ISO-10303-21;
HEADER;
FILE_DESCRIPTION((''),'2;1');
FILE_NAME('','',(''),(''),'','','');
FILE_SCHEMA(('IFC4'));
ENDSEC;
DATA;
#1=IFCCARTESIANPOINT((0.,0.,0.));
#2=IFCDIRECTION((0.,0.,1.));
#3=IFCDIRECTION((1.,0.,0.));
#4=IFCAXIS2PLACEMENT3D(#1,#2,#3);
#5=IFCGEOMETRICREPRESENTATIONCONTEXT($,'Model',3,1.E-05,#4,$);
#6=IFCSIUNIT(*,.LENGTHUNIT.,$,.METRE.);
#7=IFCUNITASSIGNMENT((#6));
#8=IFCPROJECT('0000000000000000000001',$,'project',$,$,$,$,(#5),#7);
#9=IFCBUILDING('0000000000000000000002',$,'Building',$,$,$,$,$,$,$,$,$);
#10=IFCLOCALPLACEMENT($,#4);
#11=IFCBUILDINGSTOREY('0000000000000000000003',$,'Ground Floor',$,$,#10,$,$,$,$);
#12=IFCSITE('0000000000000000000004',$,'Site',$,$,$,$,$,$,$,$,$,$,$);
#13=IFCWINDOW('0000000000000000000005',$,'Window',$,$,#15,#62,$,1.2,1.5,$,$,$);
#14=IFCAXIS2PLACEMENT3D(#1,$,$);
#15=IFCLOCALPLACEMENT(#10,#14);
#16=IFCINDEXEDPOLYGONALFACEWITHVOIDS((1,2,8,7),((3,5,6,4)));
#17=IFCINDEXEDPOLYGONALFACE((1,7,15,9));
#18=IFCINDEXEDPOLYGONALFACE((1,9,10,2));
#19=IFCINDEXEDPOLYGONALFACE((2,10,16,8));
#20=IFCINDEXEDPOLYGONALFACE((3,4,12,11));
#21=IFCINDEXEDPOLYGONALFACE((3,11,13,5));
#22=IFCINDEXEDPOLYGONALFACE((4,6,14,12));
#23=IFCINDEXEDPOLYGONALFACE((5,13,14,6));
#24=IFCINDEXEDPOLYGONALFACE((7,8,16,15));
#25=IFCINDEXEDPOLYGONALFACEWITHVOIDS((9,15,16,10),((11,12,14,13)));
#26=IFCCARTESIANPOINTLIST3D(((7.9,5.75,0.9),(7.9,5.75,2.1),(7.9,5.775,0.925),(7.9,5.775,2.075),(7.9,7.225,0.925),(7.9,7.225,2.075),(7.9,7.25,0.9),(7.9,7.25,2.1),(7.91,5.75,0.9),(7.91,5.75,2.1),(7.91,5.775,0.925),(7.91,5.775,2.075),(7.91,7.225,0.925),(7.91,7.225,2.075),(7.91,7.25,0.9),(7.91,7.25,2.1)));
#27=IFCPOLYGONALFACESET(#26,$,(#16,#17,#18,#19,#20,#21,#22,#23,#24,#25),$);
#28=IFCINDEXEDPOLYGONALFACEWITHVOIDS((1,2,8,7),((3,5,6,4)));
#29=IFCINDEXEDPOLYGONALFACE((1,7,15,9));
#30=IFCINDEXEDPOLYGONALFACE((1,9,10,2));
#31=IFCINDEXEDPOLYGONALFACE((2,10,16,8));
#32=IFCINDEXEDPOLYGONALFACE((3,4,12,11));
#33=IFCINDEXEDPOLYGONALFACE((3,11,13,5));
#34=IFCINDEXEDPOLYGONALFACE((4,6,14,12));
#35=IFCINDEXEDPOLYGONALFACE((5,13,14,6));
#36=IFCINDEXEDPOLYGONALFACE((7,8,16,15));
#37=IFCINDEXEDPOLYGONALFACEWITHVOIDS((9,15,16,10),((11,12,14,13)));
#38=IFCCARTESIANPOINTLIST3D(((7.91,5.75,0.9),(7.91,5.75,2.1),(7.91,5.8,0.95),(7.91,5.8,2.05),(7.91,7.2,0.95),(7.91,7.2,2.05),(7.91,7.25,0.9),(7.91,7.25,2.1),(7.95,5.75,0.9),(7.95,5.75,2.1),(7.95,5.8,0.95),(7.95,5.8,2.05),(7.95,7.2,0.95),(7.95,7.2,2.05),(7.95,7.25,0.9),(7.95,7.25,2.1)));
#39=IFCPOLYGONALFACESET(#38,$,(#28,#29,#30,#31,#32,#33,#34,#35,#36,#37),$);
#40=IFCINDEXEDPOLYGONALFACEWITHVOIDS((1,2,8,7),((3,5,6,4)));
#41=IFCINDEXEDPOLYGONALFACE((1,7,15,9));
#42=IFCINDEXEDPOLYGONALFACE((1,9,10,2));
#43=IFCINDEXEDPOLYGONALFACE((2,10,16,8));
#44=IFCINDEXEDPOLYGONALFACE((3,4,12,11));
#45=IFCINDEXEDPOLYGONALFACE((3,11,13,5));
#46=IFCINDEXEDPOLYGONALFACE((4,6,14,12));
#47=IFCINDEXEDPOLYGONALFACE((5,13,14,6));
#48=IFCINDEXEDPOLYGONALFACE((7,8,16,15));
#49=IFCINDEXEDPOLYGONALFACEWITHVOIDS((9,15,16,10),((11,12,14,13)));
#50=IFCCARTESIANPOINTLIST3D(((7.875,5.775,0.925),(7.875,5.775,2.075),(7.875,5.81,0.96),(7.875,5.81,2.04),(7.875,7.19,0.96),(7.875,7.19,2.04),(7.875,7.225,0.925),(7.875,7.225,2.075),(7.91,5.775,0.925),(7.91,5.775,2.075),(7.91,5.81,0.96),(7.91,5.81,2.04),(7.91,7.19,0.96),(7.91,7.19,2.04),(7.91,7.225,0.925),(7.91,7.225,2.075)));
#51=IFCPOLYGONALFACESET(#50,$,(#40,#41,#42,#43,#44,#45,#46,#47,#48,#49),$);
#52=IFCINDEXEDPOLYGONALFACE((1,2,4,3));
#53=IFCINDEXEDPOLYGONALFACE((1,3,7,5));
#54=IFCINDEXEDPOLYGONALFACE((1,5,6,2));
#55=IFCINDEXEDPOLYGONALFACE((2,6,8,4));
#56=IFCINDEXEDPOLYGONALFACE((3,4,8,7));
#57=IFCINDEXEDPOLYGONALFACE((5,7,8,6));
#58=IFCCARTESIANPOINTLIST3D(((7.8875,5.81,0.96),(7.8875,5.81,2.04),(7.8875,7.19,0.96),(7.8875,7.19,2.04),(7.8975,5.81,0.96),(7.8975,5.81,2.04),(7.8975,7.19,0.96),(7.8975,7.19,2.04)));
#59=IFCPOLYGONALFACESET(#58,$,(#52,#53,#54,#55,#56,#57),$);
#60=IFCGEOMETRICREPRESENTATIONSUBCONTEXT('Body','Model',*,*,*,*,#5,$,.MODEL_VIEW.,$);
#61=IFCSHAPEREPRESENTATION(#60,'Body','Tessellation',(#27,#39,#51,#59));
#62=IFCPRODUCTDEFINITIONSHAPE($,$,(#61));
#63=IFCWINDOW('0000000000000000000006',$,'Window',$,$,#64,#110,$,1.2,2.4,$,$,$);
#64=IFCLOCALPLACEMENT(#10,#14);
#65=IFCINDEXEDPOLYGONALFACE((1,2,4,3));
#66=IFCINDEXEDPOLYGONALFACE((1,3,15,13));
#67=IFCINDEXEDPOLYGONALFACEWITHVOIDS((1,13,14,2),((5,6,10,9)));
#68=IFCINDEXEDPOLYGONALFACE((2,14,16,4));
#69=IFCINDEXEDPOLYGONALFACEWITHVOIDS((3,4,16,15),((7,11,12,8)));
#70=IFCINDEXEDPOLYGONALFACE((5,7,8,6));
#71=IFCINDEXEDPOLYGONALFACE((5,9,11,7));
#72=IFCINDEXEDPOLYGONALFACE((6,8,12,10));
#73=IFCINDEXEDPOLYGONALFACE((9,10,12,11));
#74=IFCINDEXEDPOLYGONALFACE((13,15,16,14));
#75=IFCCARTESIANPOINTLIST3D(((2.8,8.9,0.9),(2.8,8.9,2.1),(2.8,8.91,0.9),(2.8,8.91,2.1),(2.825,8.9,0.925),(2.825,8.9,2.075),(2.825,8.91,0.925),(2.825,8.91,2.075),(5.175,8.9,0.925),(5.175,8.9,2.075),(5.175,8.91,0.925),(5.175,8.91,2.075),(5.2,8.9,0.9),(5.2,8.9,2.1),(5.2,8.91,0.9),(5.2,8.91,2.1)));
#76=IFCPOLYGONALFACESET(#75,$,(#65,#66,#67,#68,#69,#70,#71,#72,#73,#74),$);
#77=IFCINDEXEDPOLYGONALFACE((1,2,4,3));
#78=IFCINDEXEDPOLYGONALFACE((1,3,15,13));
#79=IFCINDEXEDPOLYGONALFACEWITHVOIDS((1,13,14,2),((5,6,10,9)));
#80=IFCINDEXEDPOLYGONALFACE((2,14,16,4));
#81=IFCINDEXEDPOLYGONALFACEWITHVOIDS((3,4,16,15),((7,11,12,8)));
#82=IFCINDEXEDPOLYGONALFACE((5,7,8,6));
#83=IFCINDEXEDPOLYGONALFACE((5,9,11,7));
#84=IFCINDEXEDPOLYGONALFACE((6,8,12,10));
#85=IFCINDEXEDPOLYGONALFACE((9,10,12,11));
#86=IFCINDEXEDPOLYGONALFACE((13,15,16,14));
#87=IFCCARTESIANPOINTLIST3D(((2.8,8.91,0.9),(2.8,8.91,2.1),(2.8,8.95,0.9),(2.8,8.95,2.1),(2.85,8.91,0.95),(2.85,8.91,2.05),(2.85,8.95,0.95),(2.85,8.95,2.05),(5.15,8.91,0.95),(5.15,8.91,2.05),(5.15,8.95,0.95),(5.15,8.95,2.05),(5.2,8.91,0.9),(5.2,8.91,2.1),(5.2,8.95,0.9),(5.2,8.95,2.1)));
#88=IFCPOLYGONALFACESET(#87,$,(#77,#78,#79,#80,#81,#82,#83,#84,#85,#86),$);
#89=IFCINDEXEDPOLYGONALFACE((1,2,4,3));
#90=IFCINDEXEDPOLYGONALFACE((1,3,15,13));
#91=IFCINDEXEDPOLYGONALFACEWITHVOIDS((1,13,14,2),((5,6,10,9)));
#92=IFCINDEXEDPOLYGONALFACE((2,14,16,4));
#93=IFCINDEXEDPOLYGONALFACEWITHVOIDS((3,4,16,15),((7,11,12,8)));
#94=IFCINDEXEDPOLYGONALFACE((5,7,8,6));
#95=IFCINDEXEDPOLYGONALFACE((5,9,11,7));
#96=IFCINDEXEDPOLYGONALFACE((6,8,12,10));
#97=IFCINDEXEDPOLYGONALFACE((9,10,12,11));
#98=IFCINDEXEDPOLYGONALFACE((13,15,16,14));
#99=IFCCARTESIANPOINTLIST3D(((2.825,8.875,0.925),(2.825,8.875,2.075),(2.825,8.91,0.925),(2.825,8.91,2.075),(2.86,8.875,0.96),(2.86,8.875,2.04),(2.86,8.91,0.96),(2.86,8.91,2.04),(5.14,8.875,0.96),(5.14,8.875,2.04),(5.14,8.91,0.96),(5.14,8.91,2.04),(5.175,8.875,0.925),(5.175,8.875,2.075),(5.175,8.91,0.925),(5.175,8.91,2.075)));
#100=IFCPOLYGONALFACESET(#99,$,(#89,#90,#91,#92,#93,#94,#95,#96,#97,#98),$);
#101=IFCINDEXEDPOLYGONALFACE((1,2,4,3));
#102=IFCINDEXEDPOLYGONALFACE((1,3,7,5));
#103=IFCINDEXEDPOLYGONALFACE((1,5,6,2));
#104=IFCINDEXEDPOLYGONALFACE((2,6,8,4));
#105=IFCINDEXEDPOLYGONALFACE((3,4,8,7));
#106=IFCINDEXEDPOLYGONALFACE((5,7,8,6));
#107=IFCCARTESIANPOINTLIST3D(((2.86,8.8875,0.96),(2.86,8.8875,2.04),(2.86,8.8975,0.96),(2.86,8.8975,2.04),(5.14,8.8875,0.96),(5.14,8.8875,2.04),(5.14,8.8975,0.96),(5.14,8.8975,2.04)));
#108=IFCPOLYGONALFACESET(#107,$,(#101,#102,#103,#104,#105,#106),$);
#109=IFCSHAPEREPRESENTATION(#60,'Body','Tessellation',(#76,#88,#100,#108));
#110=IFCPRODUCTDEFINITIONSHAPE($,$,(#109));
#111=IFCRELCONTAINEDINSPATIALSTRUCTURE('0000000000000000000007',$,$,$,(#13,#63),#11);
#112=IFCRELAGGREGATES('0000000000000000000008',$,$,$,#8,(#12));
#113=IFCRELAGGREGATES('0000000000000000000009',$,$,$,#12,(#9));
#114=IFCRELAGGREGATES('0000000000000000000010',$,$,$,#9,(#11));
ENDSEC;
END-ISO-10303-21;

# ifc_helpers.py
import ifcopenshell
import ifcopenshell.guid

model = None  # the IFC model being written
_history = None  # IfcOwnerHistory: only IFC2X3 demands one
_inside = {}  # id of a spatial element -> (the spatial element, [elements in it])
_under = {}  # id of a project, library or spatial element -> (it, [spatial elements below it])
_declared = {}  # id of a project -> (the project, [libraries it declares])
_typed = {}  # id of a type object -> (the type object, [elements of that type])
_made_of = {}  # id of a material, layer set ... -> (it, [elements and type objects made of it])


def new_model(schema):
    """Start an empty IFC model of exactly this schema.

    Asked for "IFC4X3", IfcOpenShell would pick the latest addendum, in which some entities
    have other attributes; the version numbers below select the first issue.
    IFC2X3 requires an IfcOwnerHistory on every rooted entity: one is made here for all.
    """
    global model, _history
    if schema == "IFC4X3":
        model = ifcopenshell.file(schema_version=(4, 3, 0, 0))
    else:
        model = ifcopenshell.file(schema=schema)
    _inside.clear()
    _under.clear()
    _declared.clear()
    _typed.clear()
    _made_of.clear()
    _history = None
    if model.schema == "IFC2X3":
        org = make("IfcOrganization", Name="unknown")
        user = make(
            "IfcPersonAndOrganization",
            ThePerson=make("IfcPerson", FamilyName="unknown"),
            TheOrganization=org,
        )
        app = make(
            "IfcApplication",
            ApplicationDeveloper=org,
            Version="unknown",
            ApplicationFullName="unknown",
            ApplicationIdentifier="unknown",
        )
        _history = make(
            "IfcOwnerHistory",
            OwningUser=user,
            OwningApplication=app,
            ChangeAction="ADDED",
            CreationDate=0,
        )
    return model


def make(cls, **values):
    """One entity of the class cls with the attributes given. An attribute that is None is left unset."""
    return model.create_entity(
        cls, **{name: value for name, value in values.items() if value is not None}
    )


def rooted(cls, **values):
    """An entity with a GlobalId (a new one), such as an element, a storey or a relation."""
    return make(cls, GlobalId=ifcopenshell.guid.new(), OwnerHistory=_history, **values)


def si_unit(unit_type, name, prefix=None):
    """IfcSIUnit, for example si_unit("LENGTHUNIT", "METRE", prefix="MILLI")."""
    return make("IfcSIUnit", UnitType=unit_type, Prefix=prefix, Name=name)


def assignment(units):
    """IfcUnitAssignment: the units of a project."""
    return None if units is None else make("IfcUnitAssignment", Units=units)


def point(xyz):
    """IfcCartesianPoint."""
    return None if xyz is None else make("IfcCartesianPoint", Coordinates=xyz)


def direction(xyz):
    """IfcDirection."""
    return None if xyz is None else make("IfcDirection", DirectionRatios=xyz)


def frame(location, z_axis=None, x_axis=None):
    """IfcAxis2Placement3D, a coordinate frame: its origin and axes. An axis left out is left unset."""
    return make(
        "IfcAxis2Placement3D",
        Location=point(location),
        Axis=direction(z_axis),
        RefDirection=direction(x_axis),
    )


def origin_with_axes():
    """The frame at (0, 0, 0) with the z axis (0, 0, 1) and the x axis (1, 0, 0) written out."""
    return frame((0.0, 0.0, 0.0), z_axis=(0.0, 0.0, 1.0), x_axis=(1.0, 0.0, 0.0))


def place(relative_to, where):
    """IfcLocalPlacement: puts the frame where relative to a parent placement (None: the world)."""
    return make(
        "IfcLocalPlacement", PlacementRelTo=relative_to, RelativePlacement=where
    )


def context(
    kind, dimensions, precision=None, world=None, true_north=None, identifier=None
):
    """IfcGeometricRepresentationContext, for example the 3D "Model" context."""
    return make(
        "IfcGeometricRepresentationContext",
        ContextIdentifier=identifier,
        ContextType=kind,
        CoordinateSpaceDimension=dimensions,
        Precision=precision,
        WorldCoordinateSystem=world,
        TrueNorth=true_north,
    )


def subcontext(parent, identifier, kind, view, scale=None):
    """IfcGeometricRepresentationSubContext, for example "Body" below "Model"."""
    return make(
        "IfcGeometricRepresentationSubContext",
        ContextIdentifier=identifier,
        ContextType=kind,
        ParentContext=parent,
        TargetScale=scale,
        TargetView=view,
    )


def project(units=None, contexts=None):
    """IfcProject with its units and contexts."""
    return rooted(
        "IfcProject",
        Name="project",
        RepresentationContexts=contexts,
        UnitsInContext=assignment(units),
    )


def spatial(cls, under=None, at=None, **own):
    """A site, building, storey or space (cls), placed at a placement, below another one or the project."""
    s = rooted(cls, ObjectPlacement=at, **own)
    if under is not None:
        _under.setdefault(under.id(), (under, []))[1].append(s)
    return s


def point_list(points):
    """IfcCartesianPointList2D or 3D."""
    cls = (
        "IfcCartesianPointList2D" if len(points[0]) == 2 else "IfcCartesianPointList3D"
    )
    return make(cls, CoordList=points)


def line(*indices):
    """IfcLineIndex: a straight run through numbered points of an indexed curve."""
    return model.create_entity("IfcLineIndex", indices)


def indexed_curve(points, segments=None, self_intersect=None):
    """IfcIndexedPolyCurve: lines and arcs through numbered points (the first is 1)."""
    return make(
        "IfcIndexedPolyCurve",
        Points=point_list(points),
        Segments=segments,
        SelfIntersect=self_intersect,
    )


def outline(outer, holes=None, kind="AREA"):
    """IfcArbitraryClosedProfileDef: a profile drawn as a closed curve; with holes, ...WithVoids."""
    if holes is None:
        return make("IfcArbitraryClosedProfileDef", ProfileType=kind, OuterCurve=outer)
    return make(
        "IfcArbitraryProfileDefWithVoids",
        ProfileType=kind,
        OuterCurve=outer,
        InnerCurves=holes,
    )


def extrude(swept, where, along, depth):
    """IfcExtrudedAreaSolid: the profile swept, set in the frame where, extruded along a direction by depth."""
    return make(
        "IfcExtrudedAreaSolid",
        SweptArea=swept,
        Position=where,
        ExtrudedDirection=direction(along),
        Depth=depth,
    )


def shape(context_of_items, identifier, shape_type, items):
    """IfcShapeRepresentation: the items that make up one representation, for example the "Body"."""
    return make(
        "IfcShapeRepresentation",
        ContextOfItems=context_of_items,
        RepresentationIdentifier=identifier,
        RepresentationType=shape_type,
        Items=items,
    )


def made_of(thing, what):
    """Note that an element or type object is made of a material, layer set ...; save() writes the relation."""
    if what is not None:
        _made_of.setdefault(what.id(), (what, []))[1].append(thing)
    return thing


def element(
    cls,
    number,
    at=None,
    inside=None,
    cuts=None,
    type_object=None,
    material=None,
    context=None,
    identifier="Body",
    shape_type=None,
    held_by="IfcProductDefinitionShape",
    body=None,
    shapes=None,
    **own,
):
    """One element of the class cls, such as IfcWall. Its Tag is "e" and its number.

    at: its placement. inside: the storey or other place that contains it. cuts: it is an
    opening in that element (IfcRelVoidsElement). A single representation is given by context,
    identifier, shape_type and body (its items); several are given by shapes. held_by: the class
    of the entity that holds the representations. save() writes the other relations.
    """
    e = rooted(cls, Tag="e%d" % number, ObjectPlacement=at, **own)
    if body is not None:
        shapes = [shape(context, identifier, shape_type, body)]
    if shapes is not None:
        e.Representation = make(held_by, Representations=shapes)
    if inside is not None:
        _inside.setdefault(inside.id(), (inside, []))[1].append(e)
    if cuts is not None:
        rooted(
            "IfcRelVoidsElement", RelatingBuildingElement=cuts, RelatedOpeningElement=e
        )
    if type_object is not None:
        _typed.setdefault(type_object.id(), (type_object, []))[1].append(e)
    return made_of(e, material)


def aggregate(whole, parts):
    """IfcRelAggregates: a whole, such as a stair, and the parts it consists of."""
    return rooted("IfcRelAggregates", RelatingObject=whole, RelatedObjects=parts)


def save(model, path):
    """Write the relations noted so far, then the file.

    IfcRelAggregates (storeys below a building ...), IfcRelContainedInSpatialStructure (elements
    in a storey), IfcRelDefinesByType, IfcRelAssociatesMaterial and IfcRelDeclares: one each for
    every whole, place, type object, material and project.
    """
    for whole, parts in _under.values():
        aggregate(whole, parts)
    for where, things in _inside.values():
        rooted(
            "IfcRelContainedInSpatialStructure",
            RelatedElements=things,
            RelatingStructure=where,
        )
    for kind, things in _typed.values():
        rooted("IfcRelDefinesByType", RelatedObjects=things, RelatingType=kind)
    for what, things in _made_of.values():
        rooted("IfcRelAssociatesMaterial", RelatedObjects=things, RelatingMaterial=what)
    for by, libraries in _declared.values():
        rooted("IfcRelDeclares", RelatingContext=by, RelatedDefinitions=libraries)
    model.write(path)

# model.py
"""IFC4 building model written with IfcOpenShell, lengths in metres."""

from ifc_helpers import new_model, si_unit, frame, origin_with_axes, place, context, subcontext, project, spatial, line, indexed_curve, outline, extrude, element, save


model = new_model("IFC4")

# Units and contexts
model_context = context("Model", 3, precision=1e-05, world=origin_with_axes())
body_context = subcontext(model_context, "Body", "Model", "MODEL_VIEW")
ifc_project = project(units=[si_unit("LENGTHUNIT", "METRE")], contexts=[model_context])

# Site, building, storey
site = spatial("IfcSite", under=ifc_project, Name="Site")
building = spatial("IfcBuilding", under=site, Name="Building")
storey_placement = place(None, origin_with_axes())
storey = spatial("IfcBuildingStorey", under=building, at=storey_placement, Name="Ground Floor")

# Windows
for number, where, z_axis, x_axis, name in (
    (1, (8.0, 5.75, 0.9), (0.0, 0.0, 1.0), (0.0, 1.0, 0.0), "Window"),
):
    element("IfcWindow", number, at=place(storey_placement, frame(where, z_axis=z_axis, x_axis=x_axis)), inside=storey, Name=name, OverallHeight=1.2, OverallWidth=1.5, context=body_context, shape_type="SweptSolid", body=[
        extrude(outline(indexed_curve([(0.0, 0.0), (1.5, 0.0), (1.5, 1.2), (0.0, 1.2)], segments=[line(1, 2, 3, 4, 1)]), holes=[indexed_curve([(0.025, 0.025), (1.475, 0.025), (1.475, 1.175), (0.025, 1.175)], segments=[line(1, 2, 3, 4, 1)])]), frame((0.0, 0.09, 0.0), z_axis=(0.0, -1.0, 0.0), x_axis=(1.0, 0.0, 0.0)), (0.0, 0.0, -1.0), 0.01),
        extrude(outline(indexed_curve([(0.0, 0.0), (1.5, 0.0), (1.5, 1.2), (0.0, 1.2)], segments=[line(1, 2, 3, 4, 1)]), holes=[indexed_curve([(0.05, 0.05), (1.45, 0.05), (1.45, 1.15), (0.05, 1.15)], segments=[line(1, 2, 3, 4, 1)])]), frame((0.0, 0.05, 0.0), z_axis=(0.0, -1.0, 0.0), x_axis=(1.0, 0.0, 0.0)), (0.0, 0.0, -1.0), 0.04),
        extrude(outline(indexed_curve([(0.0, 0.0), (1.45, 0.0), (1.45, 1.15), (0.0, 1.15)], segments=[line(1, 2, 3, 4, 1)]), holes=[indexed_curve([(0.035, 0.035), (1.415, 0.035), (1.415, 1.115), (0.035, 1.115)], segments=[line(1, 2, 3, 4, 1)])]), frame((0.025, 0.09, 0.025), z_axis=(0.0, -1.0, 0.0), x_axis=(1.0, 0.0, 0.0)), (0.0, 0.0, -1.0), 0.035),
        extrude(outline(indexed_curve([(0.035, 0.035), (1.415, 0.035), (1.415, 1.115), (0.035, 1.115)], segments=[line(1, 2, 3, 4, 1)])), frame((0.025, 0.1025, 0.025), z_axis=(0.0, -1.0, 0.0), x_axis=(1.0, 0.0, 0.0)), (0.0, 0.0, -1.0), 0.01),
    ])
window_1_placement = place(storey_placement, frame((5.2, 9.0, 0.9), z_axis=(0.0, 0.0, 1.0), x_axis=(-1.0, 0.0, 0.0)))
element("IfcWindow", 2, at=window_1_placement, inside=storey, Name="Window", OverallHeight=1.2, OverallWidth=2.4, context=body_context, shape_type="SweptSolid", body=[
    extrude(outline(indexed_curve([(0.0, 0.0), (2.4, 0.0), (2.4, 1.2), (0.0, 1.2)], segments=[line(1, 2, 3, 4, 1)]), holes=[indexed_curve([(0.025, 0.025), (2.375, 0.025), (2.375, 1.175), (0.025, 1.175)], segments=[line(1, 2, 3, 4, 1)])]), frame((0.0, 0.09, 0.0), z_axis=(0.0, -1.0, 0.0), x_axis=(1.0, 0.0, 0.0)), (0.0, 0.0, -1.0), 0.01),
    extrude(outline(indexed_curve([(0.0, 0.0), (2.4, 0.0), (2.4, 1.2), (0.0, 1.2)], segments=[line(1, 2, 3, 4, 1)]), holes=[indexed_curve([(0.05, 0.05), (2.35, 0.05), (2.35, 1.15), (0.05, 1.15)], segments=[line(1, 2, 3, 4, 1)])]), frame((0.0, 0.05, 0.0), z_axis=(0.0, -1.0, 0.0), x_axis=(1.0, 0.0, 0.0)), (0.0, 0.0, -1.0), 0.04),
    extrude(outline(indexed_curve([(0.0, 0.0), (2.35, 0.0), (2.35, 1.15), (0.0, 1.15)], segments=[line(1, 2, 3, 4, 1)]), holes=[indexed_curve([(0.035, 0.035), (2.315, 0.035), (2.315, 1.115), (0.035, 1.115)], segments=[line(1, 2, 3, 4, 1)])]), frame((0.025, 0.09, 0.025), z_axis=(0.0, -1.0, 0.0), x_axis=(1.0, 0.0, 0.0)), (0.0, 0.0, -1.0), 0.035),
    extrude(outline(indexed_curve([(0.035, 0.035), (2.315, 0.035), (2.315, 1.115), (0.035, 1.115)], segments=[line(1, 2, 3, 4, 1)])), frame((0.025, 0.1025, 0.025), z_axis=(0.0, -1.0, 0.0), x_axis=(1.0, 0.0, 0.0)), (0.0, 0.0, -1.0), 0.01),
])

save(model, "model.ifc")
